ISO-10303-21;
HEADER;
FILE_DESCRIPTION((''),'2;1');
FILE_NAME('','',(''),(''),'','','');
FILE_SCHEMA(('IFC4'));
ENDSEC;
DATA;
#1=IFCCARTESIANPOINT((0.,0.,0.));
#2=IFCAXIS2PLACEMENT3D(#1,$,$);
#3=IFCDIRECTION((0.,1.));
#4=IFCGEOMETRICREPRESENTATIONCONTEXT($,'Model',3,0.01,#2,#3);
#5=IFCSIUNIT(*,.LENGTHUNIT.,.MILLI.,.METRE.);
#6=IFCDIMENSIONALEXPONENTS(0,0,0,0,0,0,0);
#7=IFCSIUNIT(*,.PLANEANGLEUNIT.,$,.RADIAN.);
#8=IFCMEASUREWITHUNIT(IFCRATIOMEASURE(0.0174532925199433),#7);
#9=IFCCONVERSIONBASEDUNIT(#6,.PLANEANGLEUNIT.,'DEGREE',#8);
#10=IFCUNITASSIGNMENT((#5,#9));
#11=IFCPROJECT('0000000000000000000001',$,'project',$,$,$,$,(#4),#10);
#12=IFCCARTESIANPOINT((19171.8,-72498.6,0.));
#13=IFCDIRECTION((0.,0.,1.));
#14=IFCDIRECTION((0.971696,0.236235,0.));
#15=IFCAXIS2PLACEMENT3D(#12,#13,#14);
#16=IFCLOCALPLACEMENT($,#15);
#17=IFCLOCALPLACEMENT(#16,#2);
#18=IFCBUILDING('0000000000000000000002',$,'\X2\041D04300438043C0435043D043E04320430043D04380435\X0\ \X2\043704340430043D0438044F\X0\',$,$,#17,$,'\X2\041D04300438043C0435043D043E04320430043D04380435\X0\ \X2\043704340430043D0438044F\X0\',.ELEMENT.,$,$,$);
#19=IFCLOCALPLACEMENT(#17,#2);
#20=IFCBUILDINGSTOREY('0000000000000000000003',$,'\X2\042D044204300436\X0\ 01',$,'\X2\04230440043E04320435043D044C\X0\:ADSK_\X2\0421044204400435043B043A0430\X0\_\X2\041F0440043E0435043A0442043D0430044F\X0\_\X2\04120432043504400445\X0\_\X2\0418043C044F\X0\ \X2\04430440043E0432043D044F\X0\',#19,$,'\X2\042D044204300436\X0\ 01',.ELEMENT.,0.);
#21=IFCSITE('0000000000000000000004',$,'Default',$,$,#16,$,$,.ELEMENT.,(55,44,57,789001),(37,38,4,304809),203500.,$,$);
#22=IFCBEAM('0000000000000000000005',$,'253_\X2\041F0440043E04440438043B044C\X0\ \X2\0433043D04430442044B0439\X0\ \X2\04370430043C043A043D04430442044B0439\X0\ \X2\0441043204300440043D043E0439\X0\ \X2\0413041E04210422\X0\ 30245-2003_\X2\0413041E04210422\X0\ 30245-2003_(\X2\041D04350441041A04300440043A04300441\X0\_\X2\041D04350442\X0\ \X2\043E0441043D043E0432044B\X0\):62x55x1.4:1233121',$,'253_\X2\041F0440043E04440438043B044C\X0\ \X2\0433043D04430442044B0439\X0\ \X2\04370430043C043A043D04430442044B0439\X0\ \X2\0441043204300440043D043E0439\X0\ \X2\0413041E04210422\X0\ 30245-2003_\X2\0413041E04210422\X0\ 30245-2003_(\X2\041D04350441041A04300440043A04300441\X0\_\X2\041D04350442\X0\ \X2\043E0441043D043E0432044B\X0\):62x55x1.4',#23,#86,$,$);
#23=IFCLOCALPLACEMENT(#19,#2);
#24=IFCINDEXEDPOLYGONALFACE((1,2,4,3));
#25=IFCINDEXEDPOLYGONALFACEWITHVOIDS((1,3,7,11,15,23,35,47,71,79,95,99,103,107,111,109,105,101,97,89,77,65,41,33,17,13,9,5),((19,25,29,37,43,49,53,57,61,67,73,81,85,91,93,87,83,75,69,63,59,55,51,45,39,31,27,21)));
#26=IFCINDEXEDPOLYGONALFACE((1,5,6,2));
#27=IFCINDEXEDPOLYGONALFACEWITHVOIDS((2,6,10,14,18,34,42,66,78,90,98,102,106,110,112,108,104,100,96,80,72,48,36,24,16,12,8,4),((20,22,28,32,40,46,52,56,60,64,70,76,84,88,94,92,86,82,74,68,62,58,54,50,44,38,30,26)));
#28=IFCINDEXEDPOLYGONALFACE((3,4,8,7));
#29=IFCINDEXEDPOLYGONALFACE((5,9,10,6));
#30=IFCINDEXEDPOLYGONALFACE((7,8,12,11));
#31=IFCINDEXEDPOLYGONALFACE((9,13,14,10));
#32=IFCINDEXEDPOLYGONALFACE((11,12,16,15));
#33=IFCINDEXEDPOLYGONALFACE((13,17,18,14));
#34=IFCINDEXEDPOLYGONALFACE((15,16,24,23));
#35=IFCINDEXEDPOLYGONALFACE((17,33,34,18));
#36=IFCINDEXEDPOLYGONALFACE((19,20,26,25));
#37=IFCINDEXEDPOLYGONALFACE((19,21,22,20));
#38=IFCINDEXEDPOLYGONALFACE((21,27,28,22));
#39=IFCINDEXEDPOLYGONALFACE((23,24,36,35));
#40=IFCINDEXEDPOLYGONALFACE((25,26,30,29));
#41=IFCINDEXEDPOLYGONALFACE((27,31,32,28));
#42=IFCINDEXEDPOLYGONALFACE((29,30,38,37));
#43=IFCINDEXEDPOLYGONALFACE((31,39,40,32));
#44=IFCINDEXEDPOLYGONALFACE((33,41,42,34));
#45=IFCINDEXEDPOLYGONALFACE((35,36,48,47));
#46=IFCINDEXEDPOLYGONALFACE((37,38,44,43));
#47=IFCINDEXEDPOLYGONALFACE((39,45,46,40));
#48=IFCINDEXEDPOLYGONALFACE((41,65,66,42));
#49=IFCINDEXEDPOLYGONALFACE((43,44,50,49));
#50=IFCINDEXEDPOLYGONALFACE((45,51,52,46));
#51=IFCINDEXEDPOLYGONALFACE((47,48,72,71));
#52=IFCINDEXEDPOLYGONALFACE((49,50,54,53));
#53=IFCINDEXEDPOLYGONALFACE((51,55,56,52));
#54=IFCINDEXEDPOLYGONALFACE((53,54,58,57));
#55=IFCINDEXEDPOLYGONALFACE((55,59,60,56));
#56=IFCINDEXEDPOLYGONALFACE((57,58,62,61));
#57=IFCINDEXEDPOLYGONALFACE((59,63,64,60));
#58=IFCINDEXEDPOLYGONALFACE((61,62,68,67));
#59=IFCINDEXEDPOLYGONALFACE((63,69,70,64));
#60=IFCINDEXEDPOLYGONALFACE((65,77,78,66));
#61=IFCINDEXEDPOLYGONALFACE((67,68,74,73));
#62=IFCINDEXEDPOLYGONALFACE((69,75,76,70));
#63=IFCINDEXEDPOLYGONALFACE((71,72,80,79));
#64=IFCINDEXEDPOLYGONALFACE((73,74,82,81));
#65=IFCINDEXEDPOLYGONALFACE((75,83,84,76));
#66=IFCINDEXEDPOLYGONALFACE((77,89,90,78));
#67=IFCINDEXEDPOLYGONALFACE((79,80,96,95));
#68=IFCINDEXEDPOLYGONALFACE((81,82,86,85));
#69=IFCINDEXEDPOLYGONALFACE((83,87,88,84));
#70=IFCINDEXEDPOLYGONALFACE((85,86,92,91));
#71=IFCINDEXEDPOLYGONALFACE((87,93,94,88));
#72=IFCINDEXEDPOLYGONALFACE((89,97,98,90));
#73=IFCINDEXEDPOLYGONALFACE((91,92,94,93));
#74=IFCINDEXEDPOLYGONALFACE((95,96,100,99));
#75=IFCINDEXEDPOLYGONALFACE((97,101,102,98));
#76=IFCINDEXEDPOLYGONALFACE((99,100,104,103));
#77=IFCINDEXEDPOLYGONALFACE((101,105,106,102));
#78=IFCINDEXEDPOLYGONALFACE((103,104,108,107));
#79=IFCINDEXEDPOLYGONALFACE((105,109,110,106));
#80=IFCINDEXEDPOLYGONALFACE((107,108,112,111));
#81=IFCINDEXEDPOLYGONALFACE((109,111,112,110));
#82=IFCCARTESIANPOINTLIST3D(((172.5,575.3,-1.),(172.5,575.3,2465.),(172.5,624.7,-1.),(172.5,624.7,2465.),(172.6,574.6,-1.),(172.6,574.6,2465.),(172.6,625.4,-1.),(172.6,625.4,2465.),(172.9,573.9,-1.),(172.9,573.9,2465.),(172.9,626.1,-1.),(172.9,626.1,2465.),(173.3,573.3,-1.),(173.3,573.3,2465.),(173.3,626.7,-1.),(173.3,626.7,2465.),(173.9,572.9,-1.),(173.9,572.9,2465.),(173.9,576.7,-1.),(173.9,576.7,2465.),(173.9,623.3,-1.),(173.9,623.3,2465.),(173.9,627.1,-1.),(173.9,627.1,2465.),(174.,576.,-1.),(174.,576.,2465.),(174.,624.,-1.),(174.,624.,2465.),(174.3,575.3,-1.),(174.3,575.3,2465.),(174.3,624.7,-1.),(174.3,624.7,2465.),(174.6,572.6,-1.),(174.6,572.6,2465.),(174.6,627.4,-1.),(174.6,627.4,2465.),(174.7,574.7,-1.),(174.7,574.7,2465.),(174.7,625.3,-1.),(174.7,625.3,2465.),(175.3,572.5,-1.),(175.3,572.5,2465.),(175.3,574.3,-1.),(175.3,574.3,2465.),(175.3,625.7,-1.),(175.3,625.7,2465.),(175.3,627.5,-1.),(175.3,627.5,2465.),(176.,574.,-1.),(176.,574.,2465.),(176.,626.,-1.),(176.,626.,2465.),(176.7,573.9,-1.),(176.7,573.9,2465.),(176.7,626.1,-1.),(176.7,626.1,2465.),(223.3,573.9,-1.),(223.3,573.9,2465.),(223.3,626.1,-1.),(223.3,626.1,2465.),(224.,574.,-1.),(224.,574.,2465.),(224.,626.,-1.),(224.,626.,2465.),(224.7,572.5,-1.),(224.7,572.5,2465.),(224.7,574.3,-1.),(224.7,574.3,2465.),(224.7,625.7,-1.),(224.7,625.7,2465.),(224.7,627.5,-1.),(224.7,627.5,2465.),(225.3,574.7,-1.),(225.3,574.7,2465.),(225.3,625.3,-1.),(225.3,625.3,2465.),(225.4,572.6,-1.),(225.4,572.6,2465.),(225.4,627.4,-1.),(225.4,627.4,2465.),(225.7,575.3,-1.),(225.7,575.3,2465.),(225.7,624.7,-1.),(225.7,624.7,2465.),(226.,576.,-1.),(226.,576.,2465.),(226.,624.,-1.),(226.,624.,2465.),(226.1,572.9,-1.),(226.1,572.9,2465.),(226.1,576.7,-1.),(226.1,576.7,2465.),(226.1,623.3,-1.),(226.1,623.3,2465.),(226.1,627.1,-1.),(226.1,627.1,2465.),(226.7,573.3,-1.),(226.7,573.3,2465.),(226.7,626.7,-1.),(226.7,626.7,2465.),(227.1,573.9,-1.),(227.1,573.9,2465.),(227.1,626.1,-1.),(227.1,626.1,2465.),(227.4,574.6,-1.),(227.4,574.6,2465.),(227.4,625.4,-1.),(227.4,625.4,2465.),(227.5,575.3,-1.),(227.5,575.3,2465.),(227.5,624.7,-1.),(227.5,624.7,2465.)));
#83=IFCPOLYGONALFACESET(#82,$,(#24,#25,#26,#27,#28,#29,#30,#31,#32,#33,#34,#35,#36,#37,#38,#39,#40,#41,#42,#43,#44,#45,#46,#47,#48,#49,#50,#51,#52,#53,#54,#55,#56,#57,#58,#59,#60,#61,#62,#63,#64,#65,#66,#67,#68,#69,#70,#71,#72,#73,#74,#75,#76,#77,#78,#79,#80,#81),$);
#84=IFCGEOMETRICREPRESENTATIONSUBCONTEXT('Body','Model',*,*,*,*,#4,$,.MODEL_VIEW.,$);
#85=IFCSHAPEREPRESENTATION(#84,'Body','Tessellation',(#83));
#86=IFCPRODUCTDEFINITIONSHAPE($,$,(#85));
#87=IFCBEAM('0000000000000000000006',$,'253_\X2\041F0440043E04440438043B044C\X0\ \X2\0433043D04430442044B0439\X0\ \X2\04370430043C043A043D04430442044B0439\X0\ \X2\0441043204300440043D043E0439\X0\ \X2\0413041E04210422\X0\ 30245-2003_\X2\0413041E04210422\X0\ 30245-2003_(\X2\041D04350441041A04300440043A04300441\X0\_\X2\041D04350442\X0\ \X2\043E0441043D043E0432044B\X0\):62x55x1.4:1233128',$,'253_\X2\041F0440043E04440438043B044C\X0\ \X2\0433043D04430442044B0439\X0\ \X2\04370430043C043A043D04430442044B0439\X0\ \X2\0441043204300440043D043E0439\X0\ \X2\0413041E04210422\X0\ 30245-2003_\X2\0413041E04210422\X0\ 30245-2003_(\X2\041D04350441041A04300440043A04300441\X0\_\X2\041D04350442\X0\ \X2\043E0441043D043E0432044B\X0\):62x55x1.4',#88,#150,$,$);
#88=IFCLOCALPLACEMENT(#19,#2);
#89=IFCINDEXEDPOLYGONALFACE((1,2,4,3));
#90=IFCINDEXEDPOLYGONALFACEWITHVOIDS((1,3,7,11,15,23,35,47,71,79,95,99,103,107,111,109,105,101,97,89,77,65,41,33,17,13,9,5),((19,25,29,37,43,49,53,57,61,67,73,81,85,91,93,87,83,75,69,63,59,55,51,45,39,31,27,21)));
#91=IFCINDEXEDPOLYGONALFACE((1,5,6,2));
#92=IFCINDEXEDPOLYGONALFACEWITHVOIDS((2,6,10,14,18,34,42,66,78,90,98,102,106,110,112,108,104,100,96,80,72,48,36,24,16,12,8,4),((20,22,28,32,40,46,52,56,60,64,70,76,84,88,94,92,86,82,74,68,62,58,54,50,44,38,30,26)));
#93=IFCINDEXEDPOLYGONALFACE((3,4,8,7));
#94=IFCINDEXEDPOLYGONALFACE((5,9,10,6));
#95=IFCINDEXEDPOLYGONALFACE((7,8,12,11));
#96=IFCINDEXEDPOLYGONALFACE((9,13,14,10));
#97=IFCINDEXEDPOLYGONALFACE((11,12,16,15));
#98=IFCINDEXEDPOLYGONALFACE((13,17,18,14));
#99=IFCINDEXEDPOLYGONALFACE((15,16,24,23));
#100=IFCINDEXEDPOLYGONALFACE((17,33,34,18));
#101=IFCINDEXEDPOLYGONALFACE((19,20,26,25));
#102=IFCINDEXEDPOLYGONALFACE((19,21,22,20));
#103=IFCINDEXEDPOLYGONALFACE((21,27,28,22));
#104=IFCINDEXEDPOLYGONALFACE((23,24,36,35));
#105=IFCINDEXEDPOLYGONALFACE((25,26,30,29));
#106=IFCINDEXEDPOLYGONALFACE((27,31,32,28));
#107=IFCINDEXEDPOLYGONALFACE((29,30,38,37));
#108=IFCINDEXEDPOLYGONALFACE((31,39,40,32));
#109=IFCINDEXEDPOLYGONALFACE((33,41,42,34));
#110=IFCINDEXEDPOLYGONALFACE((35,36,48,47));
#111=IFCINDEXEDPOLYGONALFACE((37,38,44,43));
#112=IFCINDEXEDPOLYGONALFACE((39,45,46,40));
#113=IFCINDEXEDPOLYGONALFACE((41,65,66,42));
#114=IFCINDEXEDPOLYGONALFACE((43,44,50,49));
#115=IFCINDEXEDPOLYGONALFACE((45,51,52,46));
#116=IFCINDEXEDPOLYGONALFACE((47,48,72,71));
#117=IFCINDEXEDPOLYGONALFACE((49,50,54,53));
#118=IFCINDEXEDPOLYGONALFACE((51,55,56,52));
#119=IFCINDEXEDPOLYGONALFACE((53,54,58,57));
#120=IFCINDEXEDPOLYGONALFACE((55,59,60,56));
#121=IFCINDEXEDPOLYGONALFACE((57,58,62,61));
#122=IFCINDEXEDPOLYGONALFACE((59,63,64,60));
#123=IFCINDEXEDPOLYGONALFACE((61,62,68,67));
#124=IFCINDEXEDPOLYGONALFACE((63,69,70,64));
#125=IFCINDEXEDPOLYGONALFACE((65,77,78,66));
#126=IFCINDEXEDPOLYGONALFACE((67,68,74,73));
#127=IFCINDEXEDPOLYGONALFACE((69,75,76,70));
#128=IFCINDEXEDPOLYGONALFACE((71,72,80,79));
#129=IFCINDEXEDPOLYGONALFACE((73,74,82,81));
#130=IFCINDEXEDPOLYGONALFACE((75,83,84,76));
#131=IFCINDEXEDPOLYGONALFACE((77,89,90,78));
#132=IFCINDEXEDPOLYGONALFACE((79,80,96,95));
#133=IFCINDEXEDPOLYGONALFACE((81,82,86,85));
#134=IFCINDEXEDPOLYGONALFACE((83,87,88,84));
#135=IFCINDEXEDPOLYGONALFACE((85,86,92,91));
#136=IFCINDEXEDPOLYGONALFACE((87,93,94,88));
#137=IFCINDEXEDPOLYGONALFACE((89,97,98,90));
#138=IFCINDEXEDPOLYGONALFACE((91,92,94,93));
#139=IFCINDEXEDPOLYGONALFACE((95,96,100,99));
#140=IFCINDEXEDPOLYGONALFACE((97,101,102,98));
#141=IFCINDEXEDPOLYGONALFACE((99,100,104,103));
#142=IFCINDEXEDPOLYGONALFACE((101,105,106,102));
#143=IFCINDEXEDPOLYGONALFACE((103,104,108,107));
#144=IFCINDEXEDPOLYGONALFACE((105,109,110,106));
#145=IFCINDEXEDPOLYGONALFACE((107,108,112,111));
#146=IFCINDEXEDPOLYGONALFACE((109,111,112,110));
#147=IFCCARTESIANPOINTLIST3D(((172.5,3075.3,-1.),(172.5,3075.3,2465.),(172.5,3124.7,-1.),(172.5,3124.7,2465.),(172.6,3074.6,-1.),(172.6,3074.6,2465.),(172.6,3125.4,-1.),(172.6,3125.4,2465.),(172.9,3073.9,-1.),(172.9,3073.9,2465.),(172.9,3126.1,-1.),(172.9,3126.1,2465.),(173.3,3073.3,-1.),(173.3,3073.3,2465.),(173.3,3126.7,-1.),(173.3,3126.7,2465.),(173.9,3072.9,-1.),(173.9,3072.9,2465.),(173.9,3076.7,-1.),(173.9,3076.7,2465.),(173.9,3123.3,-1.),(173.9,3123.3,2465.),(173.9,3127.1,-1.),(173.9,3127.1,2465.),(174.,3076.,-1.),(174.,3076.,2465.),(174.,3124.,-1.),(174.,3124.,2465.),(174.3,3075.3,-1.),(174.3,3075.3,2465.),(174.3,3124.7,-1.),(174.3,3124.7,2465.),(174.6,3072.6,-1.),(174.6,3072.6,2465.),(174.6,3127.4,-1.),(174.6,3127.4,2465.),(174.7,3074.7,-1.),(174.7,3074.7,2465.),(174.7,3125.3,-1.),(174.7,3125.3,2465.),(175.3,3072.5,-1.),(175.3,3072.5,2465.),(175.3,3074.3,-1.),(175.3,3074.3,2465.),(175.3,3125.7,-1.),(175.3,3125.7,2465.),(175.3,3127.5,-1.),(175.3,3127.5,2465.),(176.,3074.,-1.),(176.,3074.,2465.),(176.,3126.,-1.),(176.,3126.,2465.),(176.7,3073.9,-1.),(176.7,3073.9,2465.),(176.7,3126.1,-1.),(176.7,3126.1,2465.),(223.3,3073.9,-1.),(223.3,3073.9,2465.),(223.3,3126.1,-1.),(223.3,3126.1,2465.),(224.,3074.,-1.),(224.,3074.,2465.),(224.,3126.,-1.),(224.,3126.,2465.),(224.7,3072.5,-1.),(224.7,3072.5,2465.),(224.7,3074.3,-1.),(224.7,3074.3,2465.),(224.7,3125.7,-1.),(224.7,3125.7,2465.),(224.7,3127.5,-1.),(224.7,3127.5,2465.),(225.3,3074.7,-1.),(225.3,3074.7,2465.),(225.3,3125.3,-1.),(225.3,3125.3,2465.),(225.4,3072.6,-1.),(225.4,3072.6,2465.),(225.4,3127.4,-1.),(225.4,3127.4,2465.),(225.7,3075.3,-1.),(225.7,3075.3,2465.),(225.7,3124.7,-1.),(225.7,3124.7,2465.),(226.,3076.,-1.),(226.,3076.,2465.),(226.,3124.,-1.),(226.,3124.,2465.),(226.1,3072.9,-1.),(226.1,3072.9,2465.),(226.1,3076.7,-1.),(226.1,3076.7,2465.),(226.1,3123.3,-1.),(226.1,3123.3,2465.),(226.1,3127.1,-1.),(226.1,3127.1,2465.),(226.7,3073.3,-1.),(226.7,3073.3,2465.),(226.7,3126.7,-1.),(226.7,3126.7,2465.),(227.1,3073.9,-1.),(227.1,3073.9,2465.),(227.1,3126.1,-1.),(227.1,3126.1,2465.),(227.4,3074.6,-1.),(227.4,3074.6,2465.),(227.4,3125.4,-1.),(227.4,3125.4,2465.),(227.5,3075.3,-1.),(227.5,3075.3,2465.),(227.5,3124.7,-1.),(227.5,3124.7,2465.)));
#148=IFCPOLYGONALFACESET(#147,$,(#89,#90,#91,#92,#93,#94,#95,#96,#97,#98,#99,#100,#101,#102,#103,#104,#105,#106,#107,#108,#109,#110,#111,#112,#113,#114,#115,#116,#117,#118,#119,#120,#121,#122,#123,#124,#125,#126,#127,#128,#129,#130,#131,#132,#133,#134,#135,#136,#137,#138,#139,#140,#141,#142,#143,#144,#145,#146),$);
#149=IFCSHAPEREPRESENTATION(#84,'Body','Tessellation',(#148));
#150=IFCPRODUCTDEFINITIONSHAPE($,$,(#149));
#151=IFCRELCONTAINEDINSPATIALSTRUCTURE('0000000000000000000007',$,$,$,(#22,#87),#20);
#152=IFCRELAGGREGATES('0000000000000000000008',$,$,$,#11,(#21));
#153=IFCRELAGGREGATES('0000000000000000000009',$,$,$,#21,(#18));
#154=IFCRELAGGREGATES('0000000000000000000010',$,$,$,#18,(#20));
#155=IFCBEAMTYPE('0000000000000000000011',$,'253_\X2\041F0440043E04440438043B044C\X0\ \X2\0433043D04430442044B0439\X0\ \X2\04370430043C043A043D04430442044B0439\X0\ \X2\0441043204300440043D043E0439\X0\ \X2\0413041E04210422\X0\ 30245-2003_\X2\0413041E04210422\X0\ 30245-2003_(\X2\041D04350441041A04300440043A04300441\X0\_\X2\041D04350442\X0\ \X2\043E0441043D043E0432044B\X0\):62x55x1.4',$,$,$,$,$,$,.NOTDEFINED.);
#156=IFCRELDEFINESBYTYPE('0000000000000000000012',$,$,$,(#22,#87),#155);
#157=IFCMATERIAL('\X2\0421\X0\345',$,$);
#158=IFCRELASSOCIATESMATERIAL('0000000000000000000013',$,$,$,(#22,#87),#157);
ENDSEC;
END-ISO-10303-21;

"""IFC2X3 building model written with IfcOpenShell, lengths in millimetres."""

from ifc_helpers import new_model, entity, si_unit, converted_unit, direction, frame, frame_2d, origin, place, context, subcontext, project, spatial, polyline, circle_curve, parameter, trimmed, segment, composite_curve, outline, extrude, material, type_object, element, save


model = new_model("IFC2X3")

# Units and contexts
model_context = context("Model", 3, precision=0.01, world=origin(), true_north=direction((0.0, 1.0)))
body_context = subcontext(model_context, "Body", "Model", "MODEL_VIEW")
ifc_project = project(units=[si_unit("LENGTHUNIT", "METRE", prefix="MILLI"), converted_unit("PLANEANGLEUNIT", "DEGREE", entity("IfcRatioMeasure", 0.0174532925199433), si_unit("PLANEANGLEUNIT", "RADIAN"), dimensions=[0, 0, 0, 0, 0, 0, 0])], contexts=[model_context])

# Site, building, storey
site_placement = place(None, frame((19171.8, -72498.6, 0.0), z_axis=(0.0, 0.0, 1.0), x_axis=(0.971696, 0.236235, 0.0)))
site = spatial("IfcSite", under=ifc_project, at=site_placement, Name="Default", CompositionType="ELEMENT", RefLatitude=(55, 44, 57, 789001), RefLongitude=(37, 38, 4, 304809), RefElevation=203500.0)
building_placement = place(site_placement, origin())
building = spatial("IfcBuilding", under=site, at=building_placement, Name="Наименование здания", LongName="Наименование здания", CompositionType="ELEMENT")
storey_placement = place(building_placement, origin())
storey = spatial("IfcBuildingStorey", under=building, at=storey_placement, Name="Этаж 01", ObjectType="Уровень:ADSK_Стрелка_Проектная_Вверх_Имя уровня", LongName="Этаж 01", CompositionType="ELEMENT", Elevation=0.0)

# Beams
ifc_material_1 = material(Name="С345")
beam_type_1 = type_object("IfcBeamType", Name="253_Профиль гнутый замкнутый сварной ГОСТ 30245-2003_ГОСТ 30245-2003_(НесКаркас_Нет основы):62x55x1.4", PredefinedType="NOTDEFINED")
beam_1_placement = place(storey_placement, frame((170.9, 570.9, -1.0), z_axis=(1.0, 0.0, 0.0), x_axis=(0.0, 0.0, 1.0)))
element("IfcBeam", 1, at=beam_1_placement, inside=storey, type_object=beam_type_1, material=ifc_material_1, Name="253_Профиль гнутый замкнутый сварной ГОСТ 30245-2003_ГОСТ 30245-2003_(НесКаркас_Нет основы):62x55x1.4:1233121", ObjectType="253_Профиль гнутый замкнутый сварной ГОСТ 30245-2003_ГОСТ 30245-2003_(НесКаркас_Нет основы):62x55x1.4", context=body_context, shape_type="SweptSolid", body=[
    extrude(outline(composite_curve([segment(trimmed(circle_curve(frame_2d((24.7, -24.7), x_axis=(1.0, 0.0)), 2.8), [parameter(270.0)], [parameter(0.0)], True, "PARAMETER"), True, "CONTINUOUS"), segment(polyline([(27.5, -24.7), (27.5, 24.7)]), True, "CONTINUOUS"), segment(trimmed(circle_curve(frame_2d((24.7, 24.7), x_axis=(1.0, 0.0)), 2.8), [parameter(0.0)], [parameter(90.0)], True, "PARAMETER"), True, "CONTINUOUS"), segment(polyline([(24.7, 27.5), (-24.7, 27.5)]), True, "CONTINUOUS"), segment(trimmed(circle_curve(frame_2d((-24.7, 24.7), x_axis=(1.0, 0.0)), 2.8), [parameter(90.0)], [parameter(180.0)], True, "PARAMETER"), True, "CONTINUOUS"), segment(polyline([(-27.5, 24.7), (-27.5, -24.7)]), True, "CONTINUOUS"), segment(trimmed(circle_curve(frame_2d((-24.7, -24.7), x_axis=(1.0, 0.0)), 2.8), [parameter(180.0)], [parameter(270.0)], True, "PARAMETER"), True, "CONTINUOUS"), segment(polyline([(-24.7, -27.5), (24.7, -27.5)]), True, "CONTINUOUS")], self_intersect=False), holes=[composite_curve([segment(polyline([(23.3, -26.1), (-23.3, -26.1)]), True, "CONTINUOUS"), segment(trimmed(circle_curve(frame_2d((-23.3, -23.3), x_axis=(1.0, 0.0)), 2.8), [parameter(180.0)], [parameter(270.0)], True, "PARAMETER"), False, "CONTINUOUS"), segment(polyline([(-26.1, -23.3), (-26.1, 23.3)]), True, "CONTINUOUS"), segment(trimmed(circle_curve(frame_2d((-23.3, 23.3), x_axis=(1.0, 0.0)), 2.8), [parameter(90.0)], [parameter(180.0)], True, "PARAMETER"), False, "CONTINUOUS"), segment(polyline([(-23.3, 26.1), (23.3, 26.1)]), True, "CONTINUOUS"), segment(trimmed(circle_curve(frame_2d((23.3, 23.3), x_axis=(1.0, 0.0)), 2.8), [parameter(0.0)], [parameter(90.0)], True, "PARAMETER"), False, "CONTINUOUS"), segment(polyline([(26.1, 23.3), (26.1, -23.3)]), True, "CONTINUOUS"), segment(trimmed(circle_curve(frame_2d((23.3, -23.3), x_axis=(1.0, 0.0)), 2.8), [parameter(270.0)], [parameter(0.0)], True, "PARAMETER"), False, "CONTINUOUS")], self_intersect=False)]), frame((0.0, -29.1, 29.1), z_axis=(1.0, 0.0, 0.0), x_axis=(0.0, -1.0, 0.0)), (0.0, 0.0, 1.0), 2466.0),
])
beam_2_placement = place(storey_placement, frame((170.9, 3070.9, -1.0), z_axis=(1.0, 0.0, 0.0), x_axis=(0.0, 0.0, 1.0)))
element("IfcBeam", 2, at=beam_2_placement, inside=storey, type_object=beam_type_1, material=ifc_material_1, Name="253_Профиль гнутый замкнутый сварной ГОСТ 30245-2003_ГОСТ 30245-2003_(НесКаркас_Нет основы):62x55x1.4:1233128", ObjectType="253_Профиль гнутый замкнутый сварной ГОСТ 30245-2003_ГОСТ 30245-2003_(НесКаркас_Нет основы):62x55x1.4", context=body_context, shape_type="SweptSolid", body=[
    extrude(outline(composite_curve([segment(trimmed(circle_curve(frame_2d((24.7, -24.7), x_axis=(1.0, 0.0)), 2.8), [parameter(270.0)], [parameter(0.0)], True, "PARAMETER"), True, "CONTINUOUS"), segment(polyline([(27.5, -24.7), (27.5, 24.7)]), True, "CONTINUOUS"), segment(trimmed(circle_curve(frame_2d((24.7, 24.7), x_axis=(1.0, 0.0)), 2.8), [parameter(0.0)], [parameter(90.0)], True, "PARAMETER"), True, "CONTINUOUS"), segment(polyline([(24.7, 27.5), (-24.7, 27.5)]), True, "CONTINUOUS"), segment(trimmed(circle_curve(frame_2d((-24.7, 24.7), x_axis=(1.0, 0.0)), 2.8), [parameter(90.0)], [parameter(180.0)], True, "PARAMETER"), True, "CONTINUOUS"), segment(polyline([(-27.5, 24.7), (-27.5, -24.7)]), True, "CONTINUOUS"), segment(trimmed(circle_curve(frame_2d((-24.7, -24.7), x_axis=(1.0, 0.0)), 2.8), [parameter(180.0)], [parameter(270.0)], True, "PARAMETER"), True, "CONTINUOUS"), segment(polyline([(-24.7, -27.5), (24.7, -27.5)]), True, "CONTINUOUS")], self_intersect=False), holes=[composite_curve([segment(polyline([(23.3, -26.1), (-23.3, -26.1)]), True, "CONTINUOUS"), segment(trimmed(circle_curve(frame_2d((-23.3, -23.3), x_axis=(1.0, 0.0)), 2.8), [parameter(180.0)], [parameter(270.0)], True, "PARAMETER"), False, "CONTINUOUS"), segment(polyline([(-26.1, -23.3), (-26.1, 23.3)]), True, "CONTINUOUS"), segment(trimmed(circle_curve(frame_2d((-23.3, 23.3), x_axis=(1.0, 0.0)), 2.8), [parameter(90.0)], [parameter(180.0)], True, "PARAMETER"), False, "CONTINUOUS"), segment(polyline([(-23.3, 26.1), (23.3, 26.1)]), True, "CONTINUOUS"), segment(trimmed(circle_curve(frame_2d((23.3, 23.3), x_axis=(1.0, 0.0)), 2.8), [parameter(0.0)], [parameter(90.0)], True, "PARAMETER"), False, "CONTINUOUS"), segment(polyline([(26.1, 23.3), (26.1, -23.3)]), True, "CONTINUOUS"), segment(trimmed(circle_curve(frame_2d((23.3, -23.3), x_axis=(1.0, 0.0)), 2.8), [parameter(270.0)], [parameter(0.0)], True, "PARAMETER"), False, "CONTINUOUS")], self_intersect=False)]), frame((0.0, -29.1, 29.1), z_axis=(1.0, 0.0, 0.0), x_axis=(0.0, -1.0, 0.0)), (0.0, 0.0, 1.0), 2466.0),
])

save(model, "model.ifc")
